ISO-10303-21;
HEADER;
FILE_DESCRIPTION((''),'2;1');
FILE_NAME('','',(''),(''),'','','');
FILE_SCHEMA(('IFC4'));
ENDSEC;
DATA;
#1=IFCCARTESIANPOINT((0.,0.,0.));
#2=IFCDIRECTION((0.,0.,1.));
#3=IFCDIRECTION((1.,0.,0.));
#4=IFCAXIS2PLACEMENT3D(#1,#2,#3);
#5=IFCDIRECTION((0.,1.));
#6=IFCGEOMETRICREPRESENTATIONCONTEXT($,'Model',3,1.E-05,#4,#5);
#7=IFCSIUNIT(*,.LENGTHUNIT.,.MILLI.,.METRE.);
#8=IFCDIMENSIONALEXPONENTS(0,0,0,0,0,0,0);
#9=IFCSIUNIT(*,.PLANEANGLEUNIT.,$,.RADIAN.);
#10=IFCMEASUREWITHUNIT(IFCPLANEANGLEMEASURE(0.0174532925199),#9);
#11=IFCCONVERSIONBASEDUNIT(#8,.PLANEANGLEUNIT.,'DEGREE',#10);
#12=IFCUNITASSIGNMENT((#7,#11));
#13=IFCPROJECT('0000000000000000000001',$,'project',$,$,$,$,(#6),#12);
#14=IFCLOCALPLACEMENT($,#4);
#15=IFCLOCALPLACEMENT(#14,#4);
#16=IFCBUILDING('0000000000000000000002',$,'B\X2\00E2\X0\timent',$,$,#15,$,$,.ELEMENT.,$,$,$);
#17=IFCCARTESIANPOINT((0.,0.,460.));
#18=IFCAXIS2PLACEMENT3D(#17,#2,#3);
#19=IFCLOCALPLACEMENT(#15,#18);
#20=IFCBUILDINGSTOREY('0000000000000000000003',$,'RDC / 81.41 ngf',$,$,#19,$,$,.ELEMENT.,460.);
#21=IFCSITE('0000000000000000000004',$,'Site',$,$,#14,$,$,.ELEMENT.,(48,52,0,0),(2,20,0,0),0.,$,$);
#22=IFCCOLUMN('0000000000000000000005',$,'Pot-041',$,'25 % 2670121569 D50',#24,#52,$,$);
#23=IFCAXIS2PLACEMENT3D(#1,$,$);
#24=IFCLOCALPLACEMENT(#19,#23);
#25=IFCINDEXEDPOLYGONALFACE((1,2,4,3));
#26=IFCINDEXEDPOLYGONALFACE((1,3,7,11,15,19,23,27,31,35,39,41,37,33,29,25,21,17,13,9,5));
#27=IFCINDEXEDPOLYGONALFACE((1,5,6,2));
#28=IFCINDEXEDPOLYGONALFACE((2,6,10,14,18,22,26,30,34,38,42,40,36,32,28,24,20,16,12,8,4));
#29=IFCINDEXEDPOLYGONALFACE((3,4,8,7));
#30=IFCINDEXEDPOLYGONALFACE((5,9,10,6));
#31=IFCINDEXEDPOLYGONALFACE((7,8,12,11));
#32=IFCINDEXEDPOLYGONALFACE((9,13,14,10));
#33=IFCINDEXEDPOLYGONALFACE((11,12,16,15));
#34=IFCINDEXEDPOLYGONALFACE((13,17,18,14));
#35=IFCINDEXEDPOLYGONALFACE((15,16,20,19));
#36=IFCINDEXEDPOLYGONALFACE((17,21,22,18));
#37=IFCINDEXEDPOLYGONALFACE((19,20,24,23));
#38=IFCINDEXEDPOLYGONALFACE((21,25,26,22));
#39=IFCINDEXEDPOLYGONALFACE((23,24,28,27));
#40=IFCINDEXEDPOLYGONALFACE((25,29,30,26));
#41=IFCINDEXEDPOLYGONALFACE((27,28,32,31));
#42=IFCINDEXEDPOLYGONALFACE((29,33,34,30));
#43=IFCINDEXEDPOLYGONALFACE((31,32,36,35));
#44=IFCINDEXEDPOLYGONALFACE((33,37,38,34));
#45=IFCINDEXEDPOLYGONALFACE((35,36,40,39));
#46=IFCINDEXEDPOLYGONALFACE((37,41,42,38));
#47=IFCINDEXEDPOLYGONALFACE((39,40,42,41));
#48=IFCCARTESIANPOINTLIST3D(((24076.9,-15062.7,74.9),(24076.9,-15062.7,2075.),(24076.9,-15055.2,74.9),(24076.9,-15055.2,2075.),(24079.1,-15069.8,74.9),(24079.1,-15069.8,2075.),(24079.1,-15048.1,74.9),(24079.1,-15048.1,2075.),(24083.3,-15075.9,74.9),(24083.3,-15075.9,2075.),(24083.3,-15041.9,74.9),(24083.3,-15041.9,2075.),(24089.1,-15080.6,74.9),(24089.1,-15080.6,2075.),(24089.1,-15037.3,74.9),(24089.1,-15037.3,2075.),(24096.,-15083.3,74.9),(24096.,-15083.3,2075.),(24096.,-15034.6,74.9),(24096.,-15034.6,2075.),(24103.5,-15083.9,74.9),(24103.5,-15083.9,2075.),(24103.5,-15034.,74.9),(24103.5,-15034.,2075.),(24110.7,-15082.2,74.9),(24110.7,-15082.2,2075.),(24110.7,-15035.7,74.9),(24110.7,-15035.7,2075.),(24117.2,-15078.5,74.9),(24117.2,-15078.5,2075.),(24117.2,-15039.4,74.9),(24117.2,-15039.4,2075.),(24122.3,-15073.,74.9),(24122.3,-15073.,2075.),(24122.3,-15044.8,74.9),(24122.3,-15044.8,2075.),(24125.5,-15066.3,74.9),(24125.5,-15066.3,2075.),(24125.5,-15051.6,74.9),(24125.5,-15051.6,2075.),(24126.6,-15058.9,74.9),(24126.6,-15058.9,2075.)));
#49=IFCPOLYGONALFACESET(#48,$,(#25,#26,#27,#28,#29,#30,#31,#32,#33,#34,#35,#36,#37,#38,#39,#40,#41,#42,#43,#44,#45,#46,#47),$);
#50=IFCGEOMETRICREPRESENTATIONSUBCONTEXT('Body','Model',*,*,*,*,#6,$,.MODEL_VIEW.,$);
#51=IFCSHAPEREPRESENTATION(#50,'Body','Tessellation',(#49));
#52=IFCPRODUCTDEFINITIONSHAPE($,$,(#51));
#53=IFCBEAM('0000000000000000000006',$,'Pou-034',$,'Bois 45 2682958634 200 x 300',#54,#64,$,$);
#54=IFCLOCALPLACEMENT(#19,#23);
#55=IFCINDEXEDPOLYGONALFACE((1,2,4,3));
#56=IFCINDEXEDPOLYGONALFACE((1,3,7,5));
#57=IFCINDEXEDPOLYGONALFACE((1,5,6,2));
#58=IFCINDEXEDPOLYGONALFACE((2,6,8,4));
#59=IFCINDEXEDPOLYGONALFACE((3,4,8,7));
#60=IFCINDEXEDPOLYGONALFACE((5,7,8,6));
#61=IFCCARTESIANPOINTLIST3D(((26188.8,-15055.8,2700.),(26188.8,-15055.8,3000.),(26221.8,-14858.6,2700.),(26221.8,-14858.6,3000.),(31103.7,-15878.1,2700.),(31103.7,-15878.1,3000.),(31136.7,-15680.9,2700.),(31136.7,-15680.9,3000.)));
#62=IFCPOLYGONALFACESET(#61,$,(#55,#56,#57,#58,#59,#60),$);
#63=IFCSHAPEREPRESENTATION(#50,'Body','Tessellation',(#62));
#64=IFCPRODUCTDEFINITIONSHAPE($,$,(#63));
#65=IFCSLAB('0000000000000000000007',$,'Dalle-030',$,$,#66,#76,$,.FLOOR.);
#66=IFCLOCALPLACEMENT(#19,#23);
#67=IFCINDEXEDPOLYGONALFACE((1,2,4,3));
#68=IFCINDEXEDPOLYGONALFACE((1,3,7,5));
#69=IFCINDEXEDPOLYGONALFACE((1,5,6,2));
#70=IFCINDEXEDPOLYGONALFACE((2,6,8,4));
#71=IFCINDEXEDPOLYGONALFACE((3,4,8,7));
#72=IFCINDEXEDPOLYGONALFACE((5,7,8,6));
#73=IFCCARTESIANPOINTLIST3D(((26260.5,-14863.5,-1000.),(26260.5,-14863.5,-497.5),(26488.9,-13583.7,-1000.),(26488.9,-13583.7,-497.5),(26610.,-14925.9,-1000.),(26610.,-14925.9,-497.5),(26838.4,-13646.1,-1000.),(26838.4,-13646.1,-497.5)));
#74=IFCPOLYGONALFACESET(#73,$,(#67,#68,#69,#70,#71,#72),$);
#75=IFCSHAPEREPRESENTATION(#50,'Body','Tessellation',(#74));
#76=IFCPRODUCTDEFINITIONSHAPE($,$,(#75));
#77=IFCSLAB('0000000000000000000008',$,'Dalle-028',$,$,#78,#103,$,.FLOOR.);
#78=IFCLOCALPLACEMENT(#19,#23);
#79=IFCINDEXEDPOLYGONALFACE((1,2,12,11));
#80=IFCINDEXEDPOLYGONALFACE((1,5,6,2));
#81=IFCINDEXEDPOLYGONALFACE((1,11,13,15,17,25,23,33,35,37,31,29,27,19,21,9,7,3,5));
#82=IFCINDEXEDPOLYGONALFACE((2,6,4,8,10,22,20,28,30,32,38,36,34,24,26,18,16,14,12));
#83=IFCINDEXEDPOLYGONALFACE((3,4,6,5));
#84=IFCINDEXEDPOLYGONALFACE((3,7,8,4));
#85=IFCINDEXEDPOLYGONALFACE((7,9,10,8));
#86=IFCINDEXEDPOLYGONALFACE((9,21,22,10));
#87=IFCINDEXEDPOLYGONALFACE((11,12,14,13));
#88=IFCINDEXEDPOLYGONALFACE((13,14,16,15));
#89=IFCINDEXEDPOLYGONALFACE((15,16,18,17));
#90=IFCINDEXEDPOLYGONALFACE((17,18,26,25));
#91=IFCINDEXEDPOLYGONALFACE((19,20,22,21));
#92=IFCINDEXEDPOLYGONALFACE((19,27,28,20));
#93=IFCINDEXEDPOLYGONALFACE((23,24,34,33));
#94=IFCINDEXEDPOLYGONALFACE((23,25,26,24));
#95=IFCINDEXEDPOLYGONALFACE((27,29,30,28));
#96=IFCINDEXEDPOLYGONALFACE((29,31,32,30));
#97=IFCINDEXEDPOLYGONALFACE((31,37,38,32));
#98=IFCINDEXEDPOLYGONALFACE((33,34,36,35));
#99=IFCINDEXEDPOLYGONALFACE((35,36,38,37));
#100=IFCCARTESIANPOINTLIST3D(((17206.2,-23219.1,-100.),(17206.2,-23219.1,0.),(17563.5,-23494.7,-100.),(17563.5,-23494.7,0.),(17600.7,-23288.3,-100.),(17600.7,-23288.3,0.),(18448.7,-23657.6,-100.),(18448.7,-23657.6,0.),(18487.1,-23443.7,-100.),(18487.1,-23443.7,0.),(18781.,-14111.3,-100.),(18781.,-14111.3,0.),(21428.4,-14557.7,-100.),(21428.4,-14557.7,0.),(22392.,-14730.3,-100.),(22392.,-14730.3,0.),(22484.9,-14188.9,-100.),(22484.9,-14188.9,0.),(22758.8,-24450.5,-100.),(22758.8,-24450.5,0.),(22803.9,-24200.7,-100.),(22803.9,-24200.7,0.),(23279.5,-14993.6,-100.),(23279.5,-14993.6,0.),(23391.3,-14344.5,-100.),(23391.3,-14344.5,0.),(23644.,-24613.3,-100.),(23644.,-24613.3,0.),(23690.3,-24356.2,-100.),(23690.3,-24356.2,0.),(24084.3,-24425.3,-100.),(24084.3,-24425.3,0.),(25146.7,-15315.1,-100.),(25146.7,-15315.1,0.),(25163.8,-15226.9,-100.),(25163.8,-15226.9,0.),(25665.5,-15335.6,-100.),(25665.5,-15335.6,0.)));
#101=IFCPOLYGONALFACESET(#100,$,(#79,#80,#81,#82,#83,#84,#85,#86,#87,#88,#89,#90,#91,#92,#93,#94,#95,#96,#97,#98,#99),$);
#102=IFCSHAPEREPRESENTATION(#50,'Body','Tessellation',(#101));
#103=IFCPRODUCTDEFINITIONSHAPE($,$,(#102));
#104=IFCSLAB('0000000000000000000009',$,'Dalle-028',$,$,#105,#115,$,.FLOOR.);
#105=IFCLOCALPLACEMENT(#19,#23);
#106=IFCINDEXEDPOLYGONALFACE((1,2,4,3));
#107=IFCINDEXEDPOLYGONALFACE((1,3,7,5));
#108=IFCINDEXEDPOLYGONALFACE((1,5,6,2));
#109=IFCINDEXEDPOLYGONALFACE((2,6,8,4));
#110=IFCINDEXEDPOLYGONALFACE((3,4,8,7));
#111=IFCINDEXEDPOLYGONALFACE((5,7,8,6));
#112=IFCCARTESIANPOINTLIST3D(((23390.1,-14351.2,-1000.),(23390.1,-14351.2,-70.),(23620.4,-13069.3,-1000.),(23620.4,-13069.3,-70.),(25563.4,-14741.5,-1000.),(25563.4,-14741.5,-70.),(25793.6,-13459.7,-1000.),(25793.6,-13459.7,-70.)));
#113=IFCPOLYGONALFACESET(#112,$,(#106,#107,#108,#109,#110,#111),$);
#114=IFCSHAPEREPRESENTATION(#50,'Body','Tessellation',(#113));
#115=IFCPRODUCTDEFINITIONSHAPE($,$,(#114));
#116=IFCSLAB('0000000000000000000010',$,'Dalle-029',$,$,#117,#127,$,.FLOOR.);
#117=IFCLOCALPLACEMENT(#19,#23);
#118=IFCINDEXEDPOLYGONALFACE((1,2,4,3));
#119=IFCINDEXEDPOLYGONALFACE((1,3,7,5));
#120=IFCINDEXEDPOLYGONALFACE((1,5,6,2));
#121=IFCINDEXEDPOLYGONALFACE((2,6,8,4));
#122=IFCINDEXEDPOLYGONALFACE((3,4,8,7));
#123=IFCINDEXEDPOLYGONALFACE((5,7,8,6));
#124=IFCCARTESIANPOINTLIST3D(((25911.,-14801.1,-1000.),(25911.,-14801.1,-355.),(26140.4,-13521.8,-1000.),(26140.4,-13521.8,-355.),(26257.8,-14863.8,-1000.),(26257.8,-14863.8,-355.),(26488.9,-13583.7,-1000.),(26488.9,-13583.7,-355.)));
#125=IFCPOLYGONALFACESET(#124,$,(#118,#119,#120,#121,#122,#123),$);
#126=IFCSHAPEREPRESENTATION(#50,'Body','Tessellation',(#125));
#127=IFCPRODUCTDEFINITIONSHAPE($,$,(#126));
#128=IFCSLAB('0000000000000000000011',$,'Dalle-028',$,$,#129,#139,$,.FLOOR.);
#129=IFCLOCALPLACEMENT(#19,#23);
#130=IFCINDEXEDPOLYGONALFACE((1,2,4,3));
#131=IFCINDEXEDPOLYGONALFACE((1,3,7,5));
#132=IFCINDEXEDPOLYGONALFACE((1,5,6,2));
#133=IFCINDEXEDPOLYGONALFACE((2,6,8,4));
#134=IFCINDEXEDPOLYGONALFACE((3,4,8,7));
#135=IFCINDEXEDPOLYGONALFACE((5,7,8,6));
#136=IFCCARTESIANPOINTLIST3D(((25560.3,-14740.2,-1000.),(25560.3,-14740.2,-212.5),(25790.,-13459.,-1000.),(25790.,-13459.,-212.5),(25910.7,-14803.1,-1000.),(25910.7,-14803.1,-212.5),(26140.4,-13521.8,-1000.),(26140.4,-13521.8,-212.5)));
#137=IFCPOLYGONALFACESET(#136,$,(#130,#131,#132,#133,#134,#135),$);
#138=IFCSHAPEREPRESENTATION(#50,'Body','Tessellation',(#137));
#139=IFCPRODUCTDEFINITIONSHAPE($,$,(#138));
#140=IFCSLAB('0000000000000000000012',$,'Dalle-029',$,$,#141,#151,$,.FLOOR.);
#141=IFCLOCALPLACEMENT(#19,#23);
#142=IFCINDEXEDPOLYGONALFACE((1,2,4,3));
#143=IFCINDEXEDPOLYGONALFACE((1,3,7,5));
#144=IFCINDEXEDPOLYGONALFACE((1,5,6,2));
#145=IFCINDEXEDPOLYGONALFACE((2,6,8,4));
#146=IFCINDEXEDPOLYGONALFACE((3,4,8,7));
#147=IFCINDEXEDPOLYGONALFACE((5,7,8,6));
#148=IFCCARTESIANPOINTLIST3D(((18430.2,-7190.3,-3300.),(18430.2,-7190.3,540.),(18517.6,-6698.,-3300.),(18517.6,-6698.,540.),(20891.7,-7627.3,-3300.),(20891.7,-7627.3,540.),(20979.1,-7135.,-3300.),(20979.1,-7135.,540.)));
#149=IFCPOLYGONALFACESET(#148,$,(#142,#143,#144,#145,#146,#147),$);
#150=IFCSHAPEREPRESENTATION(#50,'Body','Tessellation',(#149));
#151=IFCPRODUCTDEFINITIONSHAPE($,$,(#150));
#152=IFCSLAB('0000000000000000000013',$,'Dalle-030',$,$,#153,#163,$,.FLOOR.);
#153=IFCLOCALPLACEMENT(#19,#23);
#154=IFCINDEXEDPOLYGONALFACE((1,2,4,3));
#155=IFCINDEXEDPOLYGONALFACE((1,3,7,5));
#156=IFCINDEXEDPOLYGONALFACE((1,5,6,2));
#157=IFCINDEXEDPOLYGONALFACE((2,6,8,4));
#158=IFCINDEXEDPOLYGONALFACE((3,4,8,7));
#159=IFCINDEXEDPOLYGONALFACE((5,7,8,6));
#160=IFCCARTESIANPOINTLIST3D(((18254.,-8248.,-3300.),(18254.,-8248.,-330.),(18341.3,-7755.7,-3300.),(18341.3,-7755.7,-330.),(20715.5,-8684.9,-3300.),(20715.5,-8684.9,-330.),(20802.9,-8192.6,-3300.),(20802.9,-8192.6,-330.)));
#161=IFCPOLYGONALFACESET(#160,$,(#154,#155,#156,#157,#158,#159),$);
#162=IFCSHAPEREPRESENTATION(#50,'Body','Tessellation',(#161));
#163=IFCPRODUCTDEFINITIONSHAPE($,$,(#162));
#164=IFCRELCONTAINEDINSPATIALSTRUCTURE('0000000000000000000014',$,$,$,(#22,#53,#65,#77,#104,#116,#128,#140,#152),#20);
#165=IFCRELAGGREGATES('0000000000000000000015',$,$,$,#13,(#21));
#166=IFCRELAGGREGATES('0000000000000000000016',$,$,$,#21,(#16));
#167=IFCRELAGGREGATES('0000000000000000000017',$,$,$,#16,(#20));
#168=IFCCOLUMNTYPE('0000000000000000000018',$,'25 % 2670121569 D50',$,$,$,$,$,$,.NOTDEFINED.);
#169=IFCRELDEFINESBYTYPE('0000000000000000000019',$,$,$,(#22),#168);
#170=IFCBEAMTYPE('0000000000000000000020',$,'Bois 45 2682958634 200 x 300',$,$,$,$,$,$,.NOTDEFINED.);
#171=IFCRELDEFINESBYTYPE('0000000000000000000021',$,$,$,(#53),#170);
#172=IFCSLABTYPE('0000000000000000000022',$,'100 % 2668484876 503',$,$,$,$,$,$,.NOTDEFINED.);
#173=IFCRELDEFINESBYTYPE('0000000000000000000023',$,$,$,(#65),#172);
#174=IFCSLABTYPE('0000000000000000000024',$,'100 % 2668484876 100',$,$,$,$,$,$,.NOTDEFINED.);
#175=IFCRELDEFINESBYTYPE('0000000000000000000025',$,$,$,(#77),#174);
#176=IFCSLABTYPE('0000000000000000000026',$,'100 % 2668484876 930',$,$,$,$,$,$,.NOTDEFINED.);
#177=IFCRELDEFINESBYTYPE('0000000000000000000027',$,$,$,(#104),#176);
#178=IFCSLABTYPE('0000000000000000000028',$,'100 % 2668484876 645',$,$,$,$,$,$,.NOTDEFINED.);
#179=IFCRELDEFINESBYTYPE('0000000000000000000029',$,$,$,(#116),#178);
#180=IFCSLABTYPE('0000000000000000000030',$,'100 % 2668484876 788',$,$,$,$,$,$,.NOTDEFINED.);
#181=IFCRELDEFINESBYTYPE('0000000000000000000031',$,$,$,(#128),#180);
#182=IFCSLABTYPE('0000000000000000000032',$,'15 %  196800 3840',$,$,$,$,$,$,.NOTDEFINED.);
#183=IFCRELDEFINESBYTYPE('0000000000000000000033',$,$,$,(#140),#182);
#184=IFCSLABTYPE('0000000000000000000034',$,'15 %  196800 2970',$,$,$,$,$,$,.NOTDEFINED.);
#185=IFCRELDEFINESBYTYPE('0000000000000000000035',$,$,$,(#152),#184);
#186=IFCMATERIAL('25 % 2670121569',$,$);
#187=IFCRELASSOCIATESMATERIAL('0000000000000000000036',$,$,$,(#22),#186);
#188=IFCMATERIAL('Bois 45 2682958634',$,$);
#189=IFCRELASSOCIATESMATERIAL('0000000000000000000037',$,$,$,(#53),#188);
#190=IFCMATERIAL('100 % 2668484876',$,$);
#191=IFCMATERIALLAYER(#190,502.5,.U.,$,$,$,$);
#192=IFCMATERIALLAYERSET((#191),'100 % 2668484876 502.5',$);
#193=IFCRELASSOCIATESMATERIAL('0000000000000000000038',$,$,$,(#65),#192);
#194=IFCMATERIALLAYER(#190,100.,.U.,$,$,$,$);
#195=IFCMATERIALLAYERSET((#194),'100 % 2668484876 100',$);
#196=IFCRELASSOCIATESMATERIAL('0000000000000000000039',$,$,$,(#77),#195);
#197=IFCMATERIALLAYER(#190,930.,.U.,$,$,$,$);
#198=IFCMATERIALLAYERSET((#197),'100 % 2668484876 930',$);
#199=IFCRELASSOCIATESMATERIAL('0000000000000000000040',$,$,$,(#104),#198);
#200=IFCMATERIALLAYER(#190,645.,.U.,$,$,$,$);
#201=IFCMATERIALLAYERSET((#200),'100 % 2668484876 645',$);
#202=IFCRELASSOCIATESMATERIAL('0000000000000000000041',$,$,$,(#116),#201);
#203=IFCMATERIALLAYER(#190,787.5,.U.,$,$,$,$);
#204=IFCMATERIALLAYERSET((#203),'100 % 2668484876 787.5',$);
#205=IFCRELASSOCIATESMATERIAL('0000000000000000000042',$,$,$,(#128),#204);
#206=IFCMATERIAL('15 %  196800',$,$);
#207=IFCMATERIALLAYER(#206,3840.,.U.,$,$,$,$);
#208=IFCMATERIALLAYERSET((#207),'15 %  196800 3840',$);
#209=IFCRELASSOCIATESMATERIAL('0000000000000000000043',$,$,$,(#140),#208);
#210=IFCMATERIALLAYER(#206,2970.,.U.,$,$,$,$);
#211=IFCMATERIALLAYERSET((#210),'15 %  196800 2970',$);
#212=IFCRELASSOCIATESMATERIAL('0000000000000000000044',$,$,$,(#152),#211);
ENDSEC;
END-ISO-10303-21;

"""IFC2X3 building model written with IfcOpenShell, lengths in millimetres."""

from ifc_helpers import new_model, entity, si_unit, converted_unit, direction, frame, frame_2d, origin_with_axes, origin_2d_with_axis, place, context, subcontext, project, spatial, polyline, rectangle, circle, outline, extrude, material, layer, layer_set, layer_usage, type_object, element, save


model = new_model("IFC2X3")

# Units and contexts
model_context = context("Model", 3, precision=1e-05, world=origin_with_axes(), true_north=direction((0.0, 1.0)))
body_context = subcontext(model_context, "Body", "Model", "MODEL_VIEW")
ifc_project = project(units=[si_unit("LENGTHUNIT", "METRE", prefix="MILLI"), converted_unit("PLANEANGLEUNIT", "DEGREE", entity("IfcPlaneAngleMeasure", 0.0174532925199), si_unit("PLANEANGLEUNIT", "RADIAN"), dimensions=[0, 0, 0, 0, 0, 0, 0])], contexts=[model_context])

# Site, building, storey
site_placement = place(None, origin_with_axes())
site = spatial("IfcSite", under=ifc_project, at=site_placement, Name="Site", CompositionType="ELEMENT", RefLatitude=(48, 52, 0, 0), RefLongitude=(2, 20, 0, 0), RefElevation=0.0)
building_placement = place(site_placement, origin_with_axes())
building = spatial("IfcBuilding", under=site, at=building_placement, Name="Bâtiment", CompositionType="ELEMENT")
storey_placement = place(building_placement, frame((0.0, 0.0, 460.0), z_axis=(0.0, 0.0, 1.0), x_axis=(1.0, 0.0, 0.0)))
storey = spatial("IfcBuildingStorey", under=building, at=storey_placement, Name="RDC / 81.41 ngf", CompositionType="ELEMENT", Elevation=460.0)

# Column
ifc_material_1 = material(Name="25 % 2670121569")
column_type = type_object("IfcColumnType", Name="25 % 2670121569 D50", PredefinedType="NOTDEFINED")
column_placement = place(storey_placement, frame((24101.6, -15058.9, 74.9), z_axis=(0.0, 0.0, 1.0), x_axis=(1.0, 0.0, 0.0)))
element("IfcColumn", 1, at=column_placement, inside=storey, type_object=column_type, material=ifc_material_1, Name="Pot-041", ObjectType="25 % 2670121569 D50", context=body_context, shape_type="SweptSolid", body=[
    extrude(circle(Radius=25.0, at=origin_2d_with_axis()), origin_with_axes(), (0.0, 0.0, 1.0), 2000.1),
])

# Beam
ifc_material_2 = material(Name="Bois 45 2682958634")
beam_type = type_object("IfcBeamType", Name="Bois 45 2682958634 200 x 300", PredefinedType="NOTDEFINED")
beam_placement = place(storey_placement, frame((26205.3, -14957.2, 3000.0), z_axis=(0.0, 0.0, 1.0), x_axis=(-0.165016, -0.986291, 0.0)))
element("IfcBeam", 2, at=beam_placement, inside=storey, type_object=beam_type, material=ifc_material_2, Name="Pou-034", ObjectType="Bois 45 2682958634 200 x 300", context=body_context, shape_type="SweptSolid", body=[
    extrude(rectangle(XDim=300.0, YDim=200.0, at=frame_2d((-150.0, 0.0), x_axis=(1.0, 0.0))), frame((0.0, 0.0, 0.0), z_axis=(0.0, 1.0, 0.0), x_axis=(0.0, 0.0, 1.0)), (0.0, 0.0, 1.0), 4983.2),
])

# Slabs
ifc_material_3 = material(Name="100 % 2668484876")
ifc_layer_1 = layer(ifc_material_3, 502.5, ventilated="UNKNOWN")
ifc_layer_set_1 = layer_set([ifc_layer_1], Name="100 % 2668484876 502.5")
ifc_layer_usage_1 = layer_usage(ifc_layer_set_1, "AXIS3", "NEGATIVE", 502.5)
slab_type_1 = type_object("IfcSlabType", Name="100 % 2668484876 503", PredefinedType="NOTDEFINED")
slab_1_placement = place(storey_placement, frame((26488.9, -13583.7, -497.5), z_axis=(0.0, 0.0, 1.0), x_axis=(1.0, 0.0, 0.0)))
element("IfcSlab", 3, at=slab_1_placement, inside=storey, type_object=slab_type_1, material=ifc_layer_usage_1, Name="Dalle-030", PredefinedType="FLOOR", context=body_context, shape_type="SweptSolid", body=[
    extrude(outline(polyline([(0.0, 0.0), (-228.4, -1279.8), (121.1, -1342.2), (349.5, -62.4), (0.0, 0.0)])), frame((0.0, 0.0, -502.5), z_axis=(0.0, 0.0, 1.0), x_axis=(1.0, 0.0, 0.0)), (0.0, 0.0, 1.0), 502.5),
])
ifc_layer_2 = layer(ifc_material_3, 100.0, ventilated="UNKNOWN")
ifc_layer_set_2 = layer_set([ifc_layer_2], Name="100 % 2668484876 100")
ifc_layer_usage_2 = layer_usage(ifc_layer_set_2, "AXIS3", "NEGATIVE", 100.0)
slab_type_2 = type_object("IfcSlabType", Name="100 % 2668484876 100", PredefinedType="NOTDEFINED")
slab_2_placement = place(storey_placement, frame((18781.0, -14111.3, 0.0), z_axis=(0.0, 0.0, 1.0), x_axis=(1.0, 0.0, 0.0)))
element("IfcSlab", 4, at=slab_2_placement, inside=storey, type_object=slab_type_2, material=ifc_layer_usage_2, Name="Dalle-028", PredefinedType="FLOOR", context=body_context, shape_type="SweptSolid", body=[
    extrude(outline(polyline([(0.0, 0.0), (-1574.7, -9107.8), (-1180.3, -9176.9), (-1217.4, -9383.4), (-332.3, -9546.2), (-293.8, -9332.4), (4022.9, -10089.4), (3977.9, -10339.2), (4863.0, -10502.0), (4909.4, -10244.9), (5303.4, -10314.0), (6884.6, -1224.3), (6382.9, -1115.6), (6365.8, -1203.8), (4498.6, -882.3), (4610.3, -233.2), (3704.0, -77.6), (3611.0, -619.0), (2647.4, -446.3), (0.0, 0.0)])), frame((0.0, 0.0, -100.0), z_axis=(0.0, 0.0, 1.0), x_axis=(1.0, 0.0, 0.0)), (0.0, 0.0, 1.0), 100.0),
])
ifc_layer_3 = layer(ifc_material_3, 930.0, ventilated="UNKNOWN")
ifc_layer_set_3 = layer_set([ifc_layer_3], Name="100 % 2668484876 930")
ifc_layer_usage_3 = layer_usage(ifc_layer_set_3, "AXIS3", "NEGATIVE", 930.0)
slab_type_3 = type_object("IfcSlabType", Name="100 % 2668484876 930", PredefinedType="NOTDEFINED")
slab_3_placement = place(storey_placement, frame((23390.1, -14351.2, -70.0), z_axis=(0.0, 0.0, 1.0), x_axis=(1.0, 0.0, 0.0)))
element("IfcSlab", 5, at=slab_3_placement, inside=storey, type_object=slab_type_3, material=ifc_layer_usage_3, Name="Dalle-028", PredefinedType="FLOOR", context=body_context, shape_type="SweptSolid", body=[
    extrude(outline(polyline([(0.0, 0.0), (2173.2, -390.3), (2403.5, 891.5), (230.2, 1281.9), (0.0, 0.0)])), frame((0.0, 0.0, -930.0), z_axis=(0.0, 0.0, 1.0), x_axis=(1.0, 0.0, 0.0)), (0.0, 0.0, 1.0), 930.0),
])
ifc_layer_4 = layer(ifc_material_3, 645.0, ventilated="UNKNOWN")
ifc_layer_set_4 = layer_set([ifc_layer_4], Name="100 % 2668484876 645")
ifc_layer_usage_4 = layer_usage(ifc_layer_set_4, "AXIS3", "NEGATIVE", 645.0)
slab_type_4 = type_object("IfcSlabType", Name="100 % 2668484876 645", PredefinedType="NOTDEFINED")
slab_4_placement = place(storey_placement, frame((25911.0, -14801.1, -355.0), z_axis=(0.0, 0.0, 1.0), x_axis=(1.0, 0.0, 0.0)))
element("IfcSlab", 6, at=slab_4_placement, inside=storey, type_object=slab_type_4, material=ifc_layer_usage_4, Name="Dalle-029", PredefinedType="FLOOR", context=body_context, shape_type="SweptSolid", body=[
    extrude(outline(polyline([(0.0, 0.0), (346.8, -62.6), (577.9, 1217.4), (229.4, 1279.3), (0.0, 0.0)])), frame((0.0, 0.0, -645.0), z_axis=(0.0, 0.0, 1.0), x_axis=(1.0, 0.0, 0.0)), (0.0, 0.0, 1.0), 645.0),
])
ifc_layer_5 = layer(ifc_material_3, 787.5, ventilated="UNKNOWN")
ifc_layer_set_5 = layer_set([ifc_layer_5], Name="100 % 2668484876 787.5")
ifc_layer_usage_5 = layer_usage(ifc_layer_set_5, "AXIS3", "NEGATIVE", 787.5)
slab_type_5 = type_object("IfcSlabType", Name="100 % 2668484876 788", PredefinedType="NOTDEFINED")
slab_5_placement = place(storey_placement, frame((25790.0, -13459.0, -212.5), z_axis=(0.0, 0.0, 1.0), x_axis=(1.0, 0.0, 0.0)))
element("IfcSlab", 7, at=slab_5_placement, inside=storey, type_object=slab_type_5, material=ifc_layer_usage_5, Name="Dalle-028", PredefinedType="FLOOR", context=body_context, shape_type="SweptSolid", body=[
    extrude(outline(polyline([(0.0, 0.0), (-229.7, -1281.2), (120.7, -1344.1), (350.4, -62.8), (0.0, 0.0)])), frame((0.0, 0.0, -787.5), z_axis=(0.0, 0.0, 1.0), x_axis=(1.0, 0.0, 0.0)), (0.0, 0.0, 1.0), 787.5),
])
ifc_material_4 = material(Name="15 %  196800")
ifc_layer_6 = layer(ifc_material_4, 3840.0, ventilated="UNKNOWN")
ifc_layer_set_6 = layer_set([ifc_layer_6], Name="15 %  196800 3840")
ifc_layer_usage_6 = layer_usage(ifc_layer_set_6, "AXIS3", "NEGATIVE", 3840.0)
slab_type_6 = type_object("IfcSlabType", Name="15 %  196800 3840", PredefinedType="NOTDEFINED")
slab_6_placement = place(storey_placement, frame((18517.6, -6698.0, 540.0), z_axis=(0.0, 0.0, 1.0), x_axis=(1.0, 0.0, 0.0)))
element("IfcSlab", 8, at=slab_6_placement, inside=storey, type_object=slab_type_6, material=ifc_layer_usage_6, Name="Dalle-029", PredefinedType="FLOOR", context=body_context, shape_type="SweptSolid", body=[
    extrude(outline(polyline([(0.0, 0.0), (-87.4, -492.3), (2374.1, -929.3), (2461.5, -437.0), (0.0, 0.0)])), frame((0.0, 0.0, -3840.0), z_axis=(0.0, 0.0, 1.0), x_axis=(1.0, 0.0, 0.0)), (0.0, 0.0, 1.0), 3840.0),
])
ifc_layer_7 = layer(ifc_material_4, 2970.0, ventilated="UNKNOWN")
ifc_layer_set_7 = layer_set([ifc_layer_7], Name="15 %  196800 2970")
ifc_layer_usage_7 = layer_usage(ifc_layer_set_7, "AXIS3", "NEGATIVE", 2970.0)
slab_type_7 = type_object("IfcSlabType", Name="15 %  196800 2970", PredefinedType="NOTDEFINED")
slab_7_placement = place(storey_placement, frame((20802.9, -8192.6, -330.0), z_axis=(0.0, 0.0, 1.0), x_axis=(1.0, 0.0, 0.0)))
element("IfcSlab", 9, at=slab_7_placement, inside=storey, type_object=slab_type_7, material=ifc_layer_usage_7, Name="Dalle-030", PredefinedType="FLOOR", context=body_context, shape_type="SweptSolid", body=[
    extrude(outline(polyline([(0.0, 0.0), (-2461.5, 437.0), (-2548.9, -55.4), (-87.4, -492.3), (0.0, 0.0)])), frame((0.0, 0.0, -2970.0), z_axis=(0.0, 0.0, 1.0), x_axis=(1.0, 0.0, 0.0)), (0.0, 0.0, 1.0), 2970.0),
])

save(model, "model.ifc")
